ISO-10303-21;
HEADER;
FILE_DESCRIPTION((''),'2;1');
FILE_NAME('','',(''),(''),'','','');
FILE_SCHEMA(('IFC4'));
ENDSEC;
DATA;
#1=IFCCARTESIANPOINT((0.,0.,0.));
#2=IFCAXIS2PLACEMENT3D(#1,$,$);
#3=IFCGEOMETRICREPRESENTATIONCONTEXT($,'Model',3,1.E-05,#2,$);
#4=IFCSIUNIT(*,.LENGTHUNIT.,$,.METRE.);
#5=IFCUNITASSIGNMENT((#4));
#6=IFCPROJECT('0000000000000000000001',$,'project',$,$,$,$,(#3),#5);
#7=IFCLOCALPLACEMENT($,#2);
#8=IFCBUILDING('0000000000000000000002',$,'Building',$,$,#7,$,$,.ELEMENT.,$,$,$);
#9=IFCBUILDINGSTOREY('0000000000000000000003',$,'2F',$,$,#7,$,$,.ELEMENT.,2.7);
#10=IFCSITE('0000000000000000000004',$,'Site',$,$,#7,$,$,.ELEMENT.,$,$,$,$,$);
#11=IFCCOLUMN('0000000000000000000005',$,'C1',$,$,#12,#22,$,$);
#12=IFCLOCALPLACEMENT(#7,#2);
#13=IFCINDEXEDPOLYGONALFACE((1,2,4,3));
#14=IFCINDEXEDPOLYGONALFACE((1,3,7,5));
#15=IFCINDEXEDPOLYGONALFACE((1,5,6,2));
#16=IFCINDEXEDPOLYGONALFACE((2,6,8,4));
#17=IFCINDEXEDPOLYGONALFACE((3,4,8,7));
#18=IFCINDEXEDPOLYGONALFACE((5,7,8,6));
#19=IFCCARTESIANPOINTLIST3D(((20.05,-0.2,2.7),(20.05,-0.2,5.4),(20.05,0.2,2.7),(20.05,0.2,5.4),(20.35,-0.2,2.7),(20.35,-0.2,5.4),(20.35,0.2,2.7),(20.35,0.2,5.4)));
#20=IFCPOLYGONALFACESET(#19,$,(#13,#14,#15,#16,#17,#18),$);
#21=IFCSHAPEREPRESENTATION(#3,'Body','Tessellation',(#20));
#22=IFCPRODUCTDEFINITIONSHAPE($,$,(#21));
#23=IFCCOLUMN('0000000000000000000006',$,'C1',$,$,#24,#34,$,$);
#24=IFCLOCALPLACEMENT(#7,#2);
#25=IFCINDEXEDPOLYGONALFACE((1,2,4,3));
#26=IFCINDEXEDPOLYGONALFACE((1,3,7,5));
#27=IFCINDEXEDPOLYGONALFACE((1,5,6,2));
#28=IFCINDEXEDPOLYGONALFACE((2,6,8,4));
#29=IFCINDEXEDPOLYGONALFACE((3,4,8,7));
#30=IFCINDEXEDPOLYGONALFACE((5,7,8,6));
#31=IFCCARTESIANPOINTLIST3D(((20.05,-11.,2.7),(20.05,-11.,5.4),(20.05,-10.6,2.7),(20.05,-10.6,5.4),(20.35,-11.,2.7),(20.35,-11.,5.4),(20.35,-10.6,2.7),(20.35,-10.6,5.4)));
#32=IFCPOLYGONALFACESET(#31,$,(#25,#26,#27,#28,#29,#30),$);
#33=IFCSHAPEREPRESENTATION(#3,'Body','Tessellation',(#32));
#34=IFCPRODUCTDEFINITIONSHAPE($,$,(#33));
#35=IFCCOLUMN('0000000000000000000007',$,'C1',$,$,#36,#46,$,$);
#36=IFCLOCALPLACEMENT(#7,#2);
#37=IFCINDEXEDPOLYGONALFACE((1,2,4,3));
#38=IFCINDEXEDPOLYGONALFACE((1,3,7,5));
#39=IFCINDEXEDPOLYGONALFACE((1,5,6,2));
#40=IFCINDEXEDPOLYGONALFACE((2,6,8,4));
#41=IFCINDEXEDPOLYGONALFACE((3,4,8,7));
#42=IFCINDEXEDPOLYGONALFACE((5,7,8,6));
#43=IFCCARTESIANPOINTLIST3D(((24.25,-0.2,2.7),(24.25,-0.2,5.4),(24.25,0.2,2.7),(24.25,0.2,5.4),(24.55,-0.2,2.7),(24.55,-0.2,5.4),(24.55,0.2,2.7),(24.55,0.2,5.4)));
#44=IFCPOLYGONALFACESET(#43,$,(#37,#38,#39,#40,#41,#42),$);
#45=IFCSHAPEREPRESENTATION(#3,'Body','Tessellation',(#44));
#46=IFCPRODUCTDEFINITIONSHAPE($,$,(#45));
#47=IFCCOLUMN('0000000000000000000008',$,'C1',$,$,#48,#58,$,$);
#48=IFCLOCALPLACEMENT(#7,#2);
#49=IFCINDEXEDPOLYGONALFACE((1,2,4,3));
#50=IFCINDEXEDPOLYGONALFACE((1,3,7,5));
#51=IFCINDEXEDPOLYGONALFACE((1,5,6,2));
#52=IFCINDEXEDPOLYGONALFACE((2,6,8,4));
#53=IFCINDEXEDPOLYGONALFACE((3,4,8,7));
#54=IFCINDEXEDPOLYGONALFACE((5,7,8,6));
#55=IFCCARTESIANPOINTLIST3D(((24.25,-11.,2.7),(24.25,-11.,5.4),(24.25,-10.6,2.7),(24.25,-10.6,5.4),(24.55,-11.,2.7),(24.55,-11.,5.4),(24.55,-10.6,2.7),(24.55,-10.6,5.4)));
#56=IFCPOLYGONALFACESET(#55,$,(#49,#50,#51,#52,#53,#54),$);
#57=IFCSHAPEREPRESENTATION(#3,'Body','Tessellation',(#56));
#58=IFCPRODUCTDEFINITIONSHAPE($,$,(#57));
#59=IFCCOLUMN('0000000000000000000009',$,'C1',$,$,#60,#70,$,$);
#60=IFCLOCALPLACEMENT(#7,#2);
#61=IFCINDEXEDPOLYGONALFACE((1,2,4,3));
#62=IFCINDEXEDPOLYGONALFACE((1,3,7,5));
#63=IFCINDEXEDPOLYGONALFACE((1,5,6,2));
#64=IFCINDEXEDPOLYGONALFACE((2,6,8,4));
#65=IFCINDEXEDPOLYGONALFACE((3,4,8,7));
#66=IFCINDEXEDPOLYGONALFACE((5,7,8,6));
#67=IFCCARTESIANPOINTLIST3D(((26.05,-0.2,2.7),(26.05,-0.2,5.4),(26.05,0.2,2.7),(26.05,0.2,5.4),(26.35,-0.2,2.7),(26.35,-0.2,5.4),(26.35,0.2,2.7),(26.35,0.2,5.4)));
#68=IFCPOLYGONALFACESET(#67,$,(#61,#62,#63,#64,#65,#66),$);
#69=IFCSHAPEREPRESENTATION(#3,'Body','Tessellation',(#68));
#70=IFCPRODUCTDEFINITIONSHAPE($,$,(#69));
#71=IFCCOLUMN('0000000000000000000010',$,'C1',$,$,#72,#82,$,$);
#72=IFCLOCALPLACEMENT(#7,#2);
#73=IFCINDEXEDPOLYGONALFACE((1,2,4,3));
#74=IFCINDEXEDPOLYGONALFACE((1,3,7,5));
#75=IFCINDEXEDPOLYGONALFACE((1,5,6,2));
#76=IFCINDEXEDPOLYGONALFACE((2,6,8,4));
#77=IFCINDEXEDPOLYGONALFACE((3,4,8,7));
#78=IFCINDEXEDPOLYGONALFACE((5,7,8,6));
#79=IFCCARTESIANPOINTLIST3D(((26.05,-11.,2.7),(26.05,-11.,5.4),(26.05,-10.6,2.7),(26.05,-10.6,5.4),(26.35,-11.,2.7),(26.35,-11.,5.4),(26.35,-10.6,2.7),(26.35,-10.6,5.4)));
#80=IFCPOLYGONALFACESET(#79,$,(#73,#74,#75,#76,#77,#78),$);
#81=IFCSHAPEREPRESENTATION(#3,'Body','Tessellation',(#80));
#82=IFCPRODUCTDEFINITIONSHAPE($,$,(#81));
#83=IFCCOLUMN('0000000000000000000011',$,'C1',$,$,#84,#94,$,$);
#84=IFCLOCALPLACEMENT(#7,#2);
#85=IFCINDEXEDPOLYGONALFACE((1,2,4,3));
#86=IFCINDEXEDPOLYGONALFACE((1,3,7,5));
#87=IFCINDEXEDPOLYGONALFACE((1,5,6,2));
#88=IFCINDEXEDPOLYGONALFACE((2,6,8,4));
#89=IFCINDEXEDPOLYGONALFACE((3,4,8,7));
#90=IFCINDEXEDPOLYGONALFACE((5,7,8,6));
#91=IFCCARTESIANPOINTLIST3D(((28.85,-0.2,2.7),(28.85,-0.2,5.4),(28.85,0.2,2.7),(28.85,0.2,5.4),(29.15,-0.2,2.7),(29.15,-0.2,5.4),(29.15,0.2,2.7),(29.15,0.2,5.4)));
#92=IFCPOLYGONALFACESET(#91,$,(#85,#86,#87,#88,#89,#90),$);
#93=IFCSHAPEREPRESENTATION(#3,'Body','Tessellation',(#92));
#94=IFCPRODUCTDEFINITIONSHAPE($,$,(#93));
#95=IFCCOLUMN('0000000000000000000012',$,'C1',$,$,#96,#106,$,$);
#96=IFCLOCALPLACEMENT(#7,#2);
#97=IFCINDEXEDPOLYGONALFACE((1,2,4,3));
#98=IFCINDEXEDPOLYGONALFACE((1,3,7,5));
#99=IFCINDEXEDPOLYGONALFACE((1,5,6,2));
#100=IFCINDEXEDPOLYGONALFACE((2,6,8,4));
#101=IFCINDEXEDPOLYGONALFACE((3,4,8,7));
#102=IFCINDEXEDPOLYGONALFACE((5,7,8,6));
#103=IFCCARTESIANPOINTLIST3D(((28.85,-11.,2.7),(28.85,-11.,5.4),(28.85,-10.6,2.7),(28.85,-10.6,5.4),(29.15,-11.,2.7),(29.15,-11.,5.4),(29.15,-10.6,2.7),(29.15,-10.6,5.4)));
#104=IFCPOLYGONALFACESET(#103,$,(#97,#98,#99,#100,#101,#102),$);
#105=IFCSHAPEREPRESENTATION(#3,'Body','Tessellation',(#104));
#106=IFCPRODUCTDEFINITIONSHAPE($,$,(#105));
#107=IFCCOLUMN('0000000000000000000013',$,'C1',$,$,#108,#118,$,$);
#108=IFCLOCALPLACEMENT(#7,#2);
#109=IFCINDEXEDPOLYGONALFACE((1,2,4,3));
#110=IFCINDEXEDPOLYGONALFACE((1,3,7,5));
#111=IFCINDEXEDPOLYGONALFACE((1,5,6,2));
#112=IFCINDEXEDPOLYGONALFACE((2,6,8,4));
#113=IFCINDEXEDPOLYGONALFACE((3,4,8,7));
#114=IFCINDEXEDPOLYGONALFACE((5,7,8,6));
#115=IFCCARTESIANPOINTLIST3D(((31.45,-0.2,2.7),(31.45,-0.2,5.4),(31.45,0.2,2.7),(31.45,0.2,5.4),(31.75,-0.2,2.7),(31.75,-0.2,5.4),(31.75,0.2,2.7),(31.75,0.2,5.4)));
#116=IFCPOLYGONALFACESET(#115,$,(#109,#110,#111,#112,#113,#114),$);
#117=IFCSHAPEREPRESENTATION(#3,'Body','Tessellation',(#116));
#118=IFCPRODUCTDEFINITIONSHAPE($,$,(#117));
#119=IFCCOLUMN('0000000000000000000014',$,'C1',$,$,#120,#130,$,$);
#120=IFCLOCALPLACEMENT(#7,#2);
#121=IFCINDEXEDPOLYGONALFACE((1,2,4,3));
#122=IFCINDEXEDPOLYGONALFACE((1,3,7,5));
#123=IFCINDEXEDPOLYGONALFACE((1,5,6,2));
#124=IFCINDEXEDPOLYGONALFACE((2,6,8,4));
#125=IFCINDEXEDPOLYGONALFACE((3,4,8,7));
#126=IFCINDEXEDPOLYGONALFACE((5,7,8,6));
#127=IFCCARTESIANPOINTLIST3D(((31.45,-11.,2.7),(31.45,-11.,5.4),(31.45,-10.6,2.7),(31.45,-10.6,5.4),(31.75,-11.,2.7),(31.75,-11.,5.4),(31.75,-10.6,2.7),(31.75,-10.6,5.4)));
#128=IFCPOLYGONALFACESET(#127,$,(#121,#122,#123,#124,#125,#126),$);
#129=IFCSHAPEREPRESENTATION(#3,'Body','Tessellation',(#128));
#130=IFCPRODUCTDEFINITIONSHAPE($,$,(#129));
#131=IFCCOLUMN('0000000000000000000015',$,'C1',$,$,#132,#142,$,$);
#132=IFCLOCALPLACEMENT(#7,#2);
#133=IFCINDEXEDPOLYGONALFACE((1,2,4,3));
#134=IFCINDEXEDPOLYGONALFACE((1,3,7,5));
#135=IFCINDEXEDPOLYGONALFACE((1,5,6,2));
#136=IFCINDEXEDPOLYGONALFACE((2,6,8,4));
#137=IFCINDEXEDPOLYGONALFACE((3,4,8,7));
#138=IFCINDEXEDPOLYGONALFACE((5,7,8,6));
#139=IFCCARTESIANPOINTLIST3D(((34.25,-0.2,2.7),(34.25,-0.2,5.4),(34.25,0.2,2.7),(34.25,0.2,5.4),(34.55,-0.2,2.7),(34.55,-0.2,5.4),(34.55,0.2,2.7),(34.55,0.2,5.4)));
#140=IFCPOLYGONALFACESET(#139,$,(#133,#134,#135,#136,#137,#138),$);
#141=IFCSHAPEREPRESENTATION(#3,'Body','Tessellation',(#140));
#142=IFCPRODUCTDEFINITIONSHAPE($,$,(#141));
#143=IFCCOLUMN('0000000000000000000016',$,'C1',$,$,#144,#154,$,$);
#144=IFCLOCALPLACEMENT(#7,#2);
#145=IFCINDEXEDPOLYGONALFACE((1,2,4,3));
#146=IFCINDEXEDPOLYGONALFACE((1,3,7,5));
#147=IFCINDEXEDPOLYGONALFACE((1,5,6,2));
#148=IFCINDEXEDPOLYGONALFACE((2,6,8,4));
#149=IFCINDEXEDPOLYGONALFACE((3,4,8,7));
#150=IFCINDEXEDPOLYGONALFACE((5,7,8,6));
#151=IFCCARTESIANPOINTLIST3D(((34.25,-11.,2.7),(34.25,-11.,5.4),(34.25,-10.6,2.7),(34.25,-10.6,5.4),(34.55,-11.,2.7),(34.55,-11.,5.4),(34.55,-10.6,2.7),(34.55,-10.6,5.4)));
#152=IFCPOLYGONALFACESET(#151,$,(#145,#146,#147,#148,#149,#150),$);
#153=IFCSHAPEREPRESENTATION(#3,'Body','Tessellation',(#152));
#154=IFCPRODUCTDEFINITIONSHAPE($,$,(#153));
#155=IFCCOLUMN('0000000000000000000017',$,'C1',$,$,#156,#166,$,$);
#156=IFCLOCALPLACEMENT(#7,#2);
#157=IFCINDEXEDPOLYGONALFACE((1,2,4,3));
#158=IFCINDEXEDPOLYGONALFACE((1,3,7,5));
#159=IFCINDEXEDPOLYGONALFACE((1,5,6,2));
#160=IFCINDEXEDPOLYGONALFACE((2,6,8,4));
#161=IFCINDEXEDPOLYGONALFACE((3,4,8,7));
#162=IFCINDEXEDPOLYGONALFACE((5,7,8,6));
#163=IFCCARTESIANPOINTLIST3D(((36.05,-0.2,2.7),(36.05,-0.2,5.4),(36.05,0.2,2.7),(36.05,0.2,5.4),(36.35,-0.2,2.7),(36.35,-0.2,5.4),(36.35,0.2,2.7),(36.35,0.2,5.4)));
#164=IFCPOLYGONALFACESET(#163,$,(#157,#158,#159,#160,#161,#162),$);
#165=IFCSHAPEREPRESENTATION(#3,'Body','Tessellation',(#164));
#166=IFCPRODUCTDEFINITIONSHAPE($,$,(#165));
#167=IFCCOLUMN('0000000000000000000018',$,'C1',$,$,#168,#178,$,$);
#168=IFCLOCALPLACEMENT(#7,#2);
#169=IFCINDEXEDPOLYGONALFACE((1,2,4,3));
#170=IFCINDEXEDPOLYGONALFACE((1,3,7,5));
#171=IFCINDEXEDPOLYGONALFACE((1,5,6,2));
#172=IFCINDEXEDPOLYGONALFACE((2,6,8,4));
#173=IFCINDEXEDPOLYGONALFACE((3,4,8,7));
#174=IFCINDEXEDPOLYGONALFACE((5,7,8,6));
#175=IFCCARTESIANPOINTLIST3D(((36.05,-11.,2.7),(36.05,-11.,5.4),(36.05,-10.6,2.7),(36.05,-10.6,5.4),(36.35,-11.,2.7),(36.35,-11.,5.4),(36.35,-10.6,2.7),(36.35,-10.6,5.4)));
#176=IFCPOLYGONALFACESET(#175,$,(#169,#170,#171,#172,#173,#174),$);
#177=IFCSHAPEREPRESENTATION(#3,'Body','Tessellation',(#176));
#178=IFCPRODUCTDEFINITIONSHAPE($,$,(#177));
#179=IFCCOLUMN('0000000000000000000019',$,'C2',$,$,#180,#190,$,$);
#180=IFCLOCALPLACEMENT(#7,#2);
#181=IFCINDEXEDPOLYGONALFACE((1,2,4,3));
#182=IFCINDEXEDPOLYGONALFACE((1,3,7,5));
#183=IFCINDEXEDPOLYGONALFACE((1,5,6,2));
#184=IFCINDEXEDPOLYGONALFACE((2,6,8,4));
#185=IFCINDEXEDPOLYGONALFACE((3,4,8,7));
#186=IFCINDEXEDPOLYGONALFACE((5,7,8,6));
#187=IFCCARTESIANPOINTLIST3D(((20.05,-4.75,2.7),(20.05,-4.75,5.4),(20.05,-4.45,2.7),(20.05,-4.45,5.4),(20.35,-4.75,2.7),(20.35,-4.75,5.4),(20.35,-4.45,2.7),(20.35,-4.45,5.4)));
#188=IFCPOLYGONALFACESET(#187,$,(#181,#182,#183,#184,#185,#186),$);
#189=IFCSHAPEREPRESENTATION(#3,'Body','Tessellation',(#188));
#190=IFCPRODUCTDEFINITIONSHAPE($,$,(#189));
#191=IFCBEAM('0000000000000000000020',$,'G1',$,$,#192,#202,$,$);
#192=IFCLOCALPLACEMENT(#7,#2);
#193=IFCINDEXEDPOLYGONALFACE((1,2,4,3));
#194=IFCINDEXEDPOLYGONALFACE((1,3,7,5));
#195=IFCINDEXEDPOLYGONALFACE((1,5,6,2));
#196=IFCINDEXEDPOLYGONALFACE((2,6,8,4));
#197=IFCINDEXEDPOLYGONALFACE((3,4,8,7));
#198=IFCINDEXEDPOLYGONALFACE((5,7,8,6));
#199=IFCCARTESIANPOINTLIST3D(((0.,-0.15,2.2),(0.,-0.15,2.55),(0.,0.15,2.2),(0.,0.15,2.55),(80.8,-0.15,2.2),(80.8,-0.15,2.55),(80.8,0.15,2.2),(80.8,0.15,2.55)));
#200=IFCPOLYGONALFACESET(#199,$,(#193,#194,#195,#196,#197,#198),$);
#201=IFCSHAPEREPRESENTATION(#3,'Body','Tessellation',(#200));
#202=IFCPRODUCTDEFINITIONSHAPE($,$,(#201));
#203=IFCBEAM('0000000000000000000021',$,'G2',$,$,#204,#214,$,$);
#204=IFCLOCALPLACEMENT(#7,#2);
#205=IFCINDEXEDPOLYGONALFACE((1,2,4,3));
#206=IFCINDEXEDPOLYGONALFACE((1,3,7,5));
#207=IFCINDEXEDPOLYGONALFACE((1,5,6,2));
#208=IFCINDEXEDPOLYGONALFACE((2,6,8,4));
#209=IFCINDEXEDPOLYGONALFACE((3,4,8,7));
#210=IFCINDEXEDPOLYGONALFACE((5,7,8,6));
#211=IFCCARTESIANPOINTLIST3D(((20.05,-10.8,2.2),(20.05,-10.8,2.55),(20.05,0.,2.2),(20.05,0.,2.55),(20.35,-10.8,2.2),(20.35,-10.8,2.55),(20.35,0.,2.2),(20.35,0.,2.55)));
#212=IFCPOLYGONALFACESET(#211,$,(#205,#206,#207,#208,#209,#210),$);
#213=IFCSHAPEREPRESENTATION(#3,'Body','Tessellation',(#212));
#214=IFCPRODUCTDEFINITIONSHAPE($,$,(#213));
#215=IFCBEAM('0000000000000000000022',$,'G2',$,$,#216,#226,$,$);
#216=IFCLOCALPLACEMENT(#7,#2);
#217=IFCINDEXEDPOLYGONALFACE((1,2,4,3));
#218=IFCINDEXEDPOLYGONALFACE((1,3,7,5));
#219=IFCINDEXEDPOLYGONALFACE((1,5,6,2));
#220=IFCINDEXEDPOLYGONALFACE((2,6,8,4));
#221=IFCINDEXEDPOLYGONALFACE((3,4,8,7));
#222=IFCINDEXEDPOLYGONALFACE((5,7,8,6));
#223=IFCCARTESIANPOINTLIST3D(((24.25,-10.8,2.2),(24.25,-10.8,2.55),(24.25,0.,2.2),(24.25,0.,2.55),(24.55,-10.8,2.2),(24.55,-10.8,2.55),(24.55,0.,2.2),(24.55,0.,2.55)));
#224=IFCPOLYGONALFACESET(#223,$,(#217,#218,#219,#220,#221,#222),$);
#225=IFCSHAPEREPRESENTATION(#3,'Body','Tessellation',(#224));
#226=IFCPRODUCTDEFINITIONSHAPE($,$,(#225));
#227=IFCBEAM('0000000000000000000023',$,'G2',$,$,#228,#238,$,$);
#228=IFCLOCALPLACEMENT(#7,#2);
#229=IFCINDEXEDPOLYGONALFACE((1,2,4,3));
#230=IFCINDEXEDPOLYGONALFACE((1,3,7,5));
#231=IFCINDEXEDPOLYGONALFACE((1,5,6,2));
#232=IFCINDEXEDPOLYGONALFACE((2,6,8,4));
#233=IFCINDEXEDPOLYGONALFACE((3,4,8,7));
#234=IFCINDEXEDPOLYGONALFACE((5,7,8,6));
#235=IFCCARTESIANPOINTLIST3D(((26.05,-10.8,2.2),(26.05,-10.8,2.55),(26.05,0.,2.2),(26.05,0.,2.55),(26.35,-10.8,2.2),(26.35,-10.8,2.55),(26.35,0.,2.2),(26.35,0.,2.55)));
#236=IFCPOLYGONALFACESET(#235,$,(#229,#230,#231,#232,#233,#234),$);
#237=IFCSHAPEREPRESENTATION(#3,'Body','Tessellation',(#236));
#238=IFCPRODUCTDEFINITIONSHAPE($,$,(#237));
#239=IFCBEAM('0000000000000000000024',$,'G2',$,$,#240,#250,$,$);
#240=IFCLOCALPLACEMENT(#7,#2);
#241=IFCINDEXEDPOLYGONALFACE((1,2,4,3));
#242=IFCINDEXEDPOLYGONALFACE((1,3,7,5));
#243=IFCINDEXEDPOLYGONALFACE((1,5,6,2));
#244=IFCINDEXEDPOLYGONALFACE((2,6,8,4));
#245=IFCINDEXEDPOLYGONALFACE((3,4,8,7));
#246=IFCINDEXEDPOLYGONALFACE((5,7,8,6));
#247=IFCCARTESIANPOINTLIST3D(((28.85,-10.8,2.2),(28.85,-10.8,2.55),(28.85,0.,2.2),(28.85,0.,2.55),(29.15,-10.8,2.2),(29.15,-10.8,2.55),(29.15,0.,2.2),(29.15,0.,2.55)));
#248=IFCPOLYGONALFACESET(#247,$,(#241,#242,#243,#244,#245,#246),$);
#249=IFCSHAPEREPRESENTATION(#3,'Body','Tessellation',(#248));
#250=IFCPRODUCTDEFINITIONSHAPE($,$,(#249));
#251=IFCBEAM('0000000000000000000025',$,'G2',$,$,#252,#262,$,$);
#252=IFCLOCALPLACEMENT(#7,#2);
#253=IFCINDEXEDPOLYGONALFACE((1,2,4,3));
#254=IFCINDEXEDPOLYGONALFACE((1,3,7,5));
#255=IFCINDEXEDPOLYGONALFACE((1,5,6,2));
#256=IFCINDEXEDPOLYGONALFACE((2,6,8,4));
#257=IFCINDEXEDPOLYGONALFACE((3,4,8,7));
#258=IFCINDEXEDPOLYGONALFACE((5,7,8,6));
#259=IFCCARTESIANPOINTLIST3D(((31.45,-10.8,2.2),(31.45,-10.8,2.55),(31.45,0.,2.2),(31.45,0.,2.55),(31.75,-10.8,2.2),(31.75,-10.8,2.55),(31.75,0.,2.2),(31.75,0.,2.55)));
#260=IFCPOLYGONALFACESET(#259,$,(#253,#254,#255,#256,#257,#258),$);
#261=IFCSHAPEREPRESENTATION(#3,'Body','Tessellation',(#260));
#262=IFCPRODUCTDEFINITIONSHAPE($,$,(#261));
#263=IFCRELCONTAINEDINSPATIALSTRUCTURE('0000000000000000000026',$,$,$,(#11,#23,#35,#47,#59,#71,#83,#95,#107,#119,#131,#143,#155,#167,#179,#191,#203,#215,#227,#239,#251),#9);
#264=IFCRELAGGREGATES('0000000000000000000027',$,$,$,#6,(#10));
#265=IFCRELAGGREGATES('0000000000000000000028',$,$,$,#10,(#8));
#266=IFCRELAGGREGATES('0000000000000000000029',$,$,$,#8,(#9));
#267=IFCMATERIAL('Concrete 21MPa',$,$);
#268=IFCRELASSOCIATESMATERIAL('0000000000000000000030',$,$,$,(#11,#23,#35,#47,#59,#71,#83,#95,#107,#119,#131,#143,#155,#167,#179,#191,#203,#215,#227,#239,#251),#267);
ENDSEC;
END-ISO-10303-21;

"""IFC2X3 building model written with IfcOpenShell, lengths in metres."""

from ifc_helpers import new_model, si_unit, frame, origin, origin_2d, place, context, project, spatial, rectangle, extrude, material, element, save


model = new_model("IFC2X3")

# Units and contexts
model_context = context("Model", 3, precision=1e-05, world=origin())
ifc_project = project(units=[si_unit("LENGTHUNIT", "METRE")], contexts=[model_context])

# Site, building, storey
placement = place(None, origin())
site = spatial("IfcSite", under=ifc_project, at=placement, Name="Site", CompositionType="ELEMENT")
building = spatial("IfcBuilding", under=site, at=placement, Name="Building", CompositionType="ELEMENT")
storey = spatial("IfcBuildingStorey", under=building, at=placement, Name="2F", CompositionType="ELEMENT", Elevation=2.7)

# Columns
ifc_material_1 = material(Name="Concrete 21MPa")
for number, where, name in (
    (1, (20.2, 0.0, 2.7), "C1"),
    (2, (20.2, -10.8, 2.7), "C1"),
    (3, (24.4, 0.0, 2.7), "C1"),
    (4, (24.4, -10.8, 2.7), "C1"),
    (5, (26.2, 0.0, 2.7), "C1"),
    (6, (26.2, -10.8, 2.7), "C1"),
    (7, (29.0, 0.0, 2.7), "C1"),
    (8, (29.0, -10.8, 2.7), "C1"),
    (9, (31.6, 0.0, 2.7), "C1"),
    (10, (31.6, -10.8, 2.7), "C1"),
    (11, (34.4, 0.0, 2.7), "C1"),
    (12, (34.4, -10.8, 2.7), "C1"),
    (13, (36.2, 0.0, 2.7), "C1"),
    (14, (36.2, -10.8, 2.7), "C1"),
):
    element("IfcColumn", number, at=place(None, frame(where)), inside=storey, material=ifc_material_1, Name=name, context=model_context, shape_type="SweptSolid", body=[
        extrude(rectangle(XDim=0.3, YDim=0.4, at=origin_2d()), origin(), (0.0, 0.0, 1.0), 2.7),
    ])
column_placement = place(None, frame((20.2, -4.6, 2.7)))
element("IfcColumn", 15, at=column_placement, inside=storey, material=ifc_material_1, Name="C2", context=model_context, shape_type="SweptSolid", body=[
    extrude(rectangle(XDim=0.3, YDim=0.3, at=origin_2d()), origin(), (0.0, 0.0, 1.0), 2.7),
])

# Beams
beam_placement = place(None, frame((40.4, 0.0, 2.2)))
element("IfcBeam", 16, at=beam_placement, inside=storey, material=ifc_material_1, Name="G1", context=model_context, shape_type="SweptSolid", body=[
    extrude(rectangle(XDim=80.8, YDim=0.3, at=origin_2d()), origin(), (0.0, 0.0, 1.0), 0.35),
])
for number, where, name in (
    (17, (20.2, -5.4, 2.2), "G2"),
    (18, (24.4, -5.4, 2.2), "G2"),
    (19, (26.2, -5.4, 2.2), "G2"),
    (20, (29.0, -5.4, 2.2), "G2"),
    (21, (31.6, -5.4, 2.2), "G2"),
):
    element("IfcBeam", number, at=place(None, frame(where)), inside=storey, material=ifc_material_1, Name=name, context=model_context, shape_type="SweptSolid", body=[
        extrude(rectangle(XDim=0.3, YDim=10.8, at=origin_2d()), origin(), (0.0, 0.0, 1.0), 0.35),
    ])

save(model, "model.ifc")
